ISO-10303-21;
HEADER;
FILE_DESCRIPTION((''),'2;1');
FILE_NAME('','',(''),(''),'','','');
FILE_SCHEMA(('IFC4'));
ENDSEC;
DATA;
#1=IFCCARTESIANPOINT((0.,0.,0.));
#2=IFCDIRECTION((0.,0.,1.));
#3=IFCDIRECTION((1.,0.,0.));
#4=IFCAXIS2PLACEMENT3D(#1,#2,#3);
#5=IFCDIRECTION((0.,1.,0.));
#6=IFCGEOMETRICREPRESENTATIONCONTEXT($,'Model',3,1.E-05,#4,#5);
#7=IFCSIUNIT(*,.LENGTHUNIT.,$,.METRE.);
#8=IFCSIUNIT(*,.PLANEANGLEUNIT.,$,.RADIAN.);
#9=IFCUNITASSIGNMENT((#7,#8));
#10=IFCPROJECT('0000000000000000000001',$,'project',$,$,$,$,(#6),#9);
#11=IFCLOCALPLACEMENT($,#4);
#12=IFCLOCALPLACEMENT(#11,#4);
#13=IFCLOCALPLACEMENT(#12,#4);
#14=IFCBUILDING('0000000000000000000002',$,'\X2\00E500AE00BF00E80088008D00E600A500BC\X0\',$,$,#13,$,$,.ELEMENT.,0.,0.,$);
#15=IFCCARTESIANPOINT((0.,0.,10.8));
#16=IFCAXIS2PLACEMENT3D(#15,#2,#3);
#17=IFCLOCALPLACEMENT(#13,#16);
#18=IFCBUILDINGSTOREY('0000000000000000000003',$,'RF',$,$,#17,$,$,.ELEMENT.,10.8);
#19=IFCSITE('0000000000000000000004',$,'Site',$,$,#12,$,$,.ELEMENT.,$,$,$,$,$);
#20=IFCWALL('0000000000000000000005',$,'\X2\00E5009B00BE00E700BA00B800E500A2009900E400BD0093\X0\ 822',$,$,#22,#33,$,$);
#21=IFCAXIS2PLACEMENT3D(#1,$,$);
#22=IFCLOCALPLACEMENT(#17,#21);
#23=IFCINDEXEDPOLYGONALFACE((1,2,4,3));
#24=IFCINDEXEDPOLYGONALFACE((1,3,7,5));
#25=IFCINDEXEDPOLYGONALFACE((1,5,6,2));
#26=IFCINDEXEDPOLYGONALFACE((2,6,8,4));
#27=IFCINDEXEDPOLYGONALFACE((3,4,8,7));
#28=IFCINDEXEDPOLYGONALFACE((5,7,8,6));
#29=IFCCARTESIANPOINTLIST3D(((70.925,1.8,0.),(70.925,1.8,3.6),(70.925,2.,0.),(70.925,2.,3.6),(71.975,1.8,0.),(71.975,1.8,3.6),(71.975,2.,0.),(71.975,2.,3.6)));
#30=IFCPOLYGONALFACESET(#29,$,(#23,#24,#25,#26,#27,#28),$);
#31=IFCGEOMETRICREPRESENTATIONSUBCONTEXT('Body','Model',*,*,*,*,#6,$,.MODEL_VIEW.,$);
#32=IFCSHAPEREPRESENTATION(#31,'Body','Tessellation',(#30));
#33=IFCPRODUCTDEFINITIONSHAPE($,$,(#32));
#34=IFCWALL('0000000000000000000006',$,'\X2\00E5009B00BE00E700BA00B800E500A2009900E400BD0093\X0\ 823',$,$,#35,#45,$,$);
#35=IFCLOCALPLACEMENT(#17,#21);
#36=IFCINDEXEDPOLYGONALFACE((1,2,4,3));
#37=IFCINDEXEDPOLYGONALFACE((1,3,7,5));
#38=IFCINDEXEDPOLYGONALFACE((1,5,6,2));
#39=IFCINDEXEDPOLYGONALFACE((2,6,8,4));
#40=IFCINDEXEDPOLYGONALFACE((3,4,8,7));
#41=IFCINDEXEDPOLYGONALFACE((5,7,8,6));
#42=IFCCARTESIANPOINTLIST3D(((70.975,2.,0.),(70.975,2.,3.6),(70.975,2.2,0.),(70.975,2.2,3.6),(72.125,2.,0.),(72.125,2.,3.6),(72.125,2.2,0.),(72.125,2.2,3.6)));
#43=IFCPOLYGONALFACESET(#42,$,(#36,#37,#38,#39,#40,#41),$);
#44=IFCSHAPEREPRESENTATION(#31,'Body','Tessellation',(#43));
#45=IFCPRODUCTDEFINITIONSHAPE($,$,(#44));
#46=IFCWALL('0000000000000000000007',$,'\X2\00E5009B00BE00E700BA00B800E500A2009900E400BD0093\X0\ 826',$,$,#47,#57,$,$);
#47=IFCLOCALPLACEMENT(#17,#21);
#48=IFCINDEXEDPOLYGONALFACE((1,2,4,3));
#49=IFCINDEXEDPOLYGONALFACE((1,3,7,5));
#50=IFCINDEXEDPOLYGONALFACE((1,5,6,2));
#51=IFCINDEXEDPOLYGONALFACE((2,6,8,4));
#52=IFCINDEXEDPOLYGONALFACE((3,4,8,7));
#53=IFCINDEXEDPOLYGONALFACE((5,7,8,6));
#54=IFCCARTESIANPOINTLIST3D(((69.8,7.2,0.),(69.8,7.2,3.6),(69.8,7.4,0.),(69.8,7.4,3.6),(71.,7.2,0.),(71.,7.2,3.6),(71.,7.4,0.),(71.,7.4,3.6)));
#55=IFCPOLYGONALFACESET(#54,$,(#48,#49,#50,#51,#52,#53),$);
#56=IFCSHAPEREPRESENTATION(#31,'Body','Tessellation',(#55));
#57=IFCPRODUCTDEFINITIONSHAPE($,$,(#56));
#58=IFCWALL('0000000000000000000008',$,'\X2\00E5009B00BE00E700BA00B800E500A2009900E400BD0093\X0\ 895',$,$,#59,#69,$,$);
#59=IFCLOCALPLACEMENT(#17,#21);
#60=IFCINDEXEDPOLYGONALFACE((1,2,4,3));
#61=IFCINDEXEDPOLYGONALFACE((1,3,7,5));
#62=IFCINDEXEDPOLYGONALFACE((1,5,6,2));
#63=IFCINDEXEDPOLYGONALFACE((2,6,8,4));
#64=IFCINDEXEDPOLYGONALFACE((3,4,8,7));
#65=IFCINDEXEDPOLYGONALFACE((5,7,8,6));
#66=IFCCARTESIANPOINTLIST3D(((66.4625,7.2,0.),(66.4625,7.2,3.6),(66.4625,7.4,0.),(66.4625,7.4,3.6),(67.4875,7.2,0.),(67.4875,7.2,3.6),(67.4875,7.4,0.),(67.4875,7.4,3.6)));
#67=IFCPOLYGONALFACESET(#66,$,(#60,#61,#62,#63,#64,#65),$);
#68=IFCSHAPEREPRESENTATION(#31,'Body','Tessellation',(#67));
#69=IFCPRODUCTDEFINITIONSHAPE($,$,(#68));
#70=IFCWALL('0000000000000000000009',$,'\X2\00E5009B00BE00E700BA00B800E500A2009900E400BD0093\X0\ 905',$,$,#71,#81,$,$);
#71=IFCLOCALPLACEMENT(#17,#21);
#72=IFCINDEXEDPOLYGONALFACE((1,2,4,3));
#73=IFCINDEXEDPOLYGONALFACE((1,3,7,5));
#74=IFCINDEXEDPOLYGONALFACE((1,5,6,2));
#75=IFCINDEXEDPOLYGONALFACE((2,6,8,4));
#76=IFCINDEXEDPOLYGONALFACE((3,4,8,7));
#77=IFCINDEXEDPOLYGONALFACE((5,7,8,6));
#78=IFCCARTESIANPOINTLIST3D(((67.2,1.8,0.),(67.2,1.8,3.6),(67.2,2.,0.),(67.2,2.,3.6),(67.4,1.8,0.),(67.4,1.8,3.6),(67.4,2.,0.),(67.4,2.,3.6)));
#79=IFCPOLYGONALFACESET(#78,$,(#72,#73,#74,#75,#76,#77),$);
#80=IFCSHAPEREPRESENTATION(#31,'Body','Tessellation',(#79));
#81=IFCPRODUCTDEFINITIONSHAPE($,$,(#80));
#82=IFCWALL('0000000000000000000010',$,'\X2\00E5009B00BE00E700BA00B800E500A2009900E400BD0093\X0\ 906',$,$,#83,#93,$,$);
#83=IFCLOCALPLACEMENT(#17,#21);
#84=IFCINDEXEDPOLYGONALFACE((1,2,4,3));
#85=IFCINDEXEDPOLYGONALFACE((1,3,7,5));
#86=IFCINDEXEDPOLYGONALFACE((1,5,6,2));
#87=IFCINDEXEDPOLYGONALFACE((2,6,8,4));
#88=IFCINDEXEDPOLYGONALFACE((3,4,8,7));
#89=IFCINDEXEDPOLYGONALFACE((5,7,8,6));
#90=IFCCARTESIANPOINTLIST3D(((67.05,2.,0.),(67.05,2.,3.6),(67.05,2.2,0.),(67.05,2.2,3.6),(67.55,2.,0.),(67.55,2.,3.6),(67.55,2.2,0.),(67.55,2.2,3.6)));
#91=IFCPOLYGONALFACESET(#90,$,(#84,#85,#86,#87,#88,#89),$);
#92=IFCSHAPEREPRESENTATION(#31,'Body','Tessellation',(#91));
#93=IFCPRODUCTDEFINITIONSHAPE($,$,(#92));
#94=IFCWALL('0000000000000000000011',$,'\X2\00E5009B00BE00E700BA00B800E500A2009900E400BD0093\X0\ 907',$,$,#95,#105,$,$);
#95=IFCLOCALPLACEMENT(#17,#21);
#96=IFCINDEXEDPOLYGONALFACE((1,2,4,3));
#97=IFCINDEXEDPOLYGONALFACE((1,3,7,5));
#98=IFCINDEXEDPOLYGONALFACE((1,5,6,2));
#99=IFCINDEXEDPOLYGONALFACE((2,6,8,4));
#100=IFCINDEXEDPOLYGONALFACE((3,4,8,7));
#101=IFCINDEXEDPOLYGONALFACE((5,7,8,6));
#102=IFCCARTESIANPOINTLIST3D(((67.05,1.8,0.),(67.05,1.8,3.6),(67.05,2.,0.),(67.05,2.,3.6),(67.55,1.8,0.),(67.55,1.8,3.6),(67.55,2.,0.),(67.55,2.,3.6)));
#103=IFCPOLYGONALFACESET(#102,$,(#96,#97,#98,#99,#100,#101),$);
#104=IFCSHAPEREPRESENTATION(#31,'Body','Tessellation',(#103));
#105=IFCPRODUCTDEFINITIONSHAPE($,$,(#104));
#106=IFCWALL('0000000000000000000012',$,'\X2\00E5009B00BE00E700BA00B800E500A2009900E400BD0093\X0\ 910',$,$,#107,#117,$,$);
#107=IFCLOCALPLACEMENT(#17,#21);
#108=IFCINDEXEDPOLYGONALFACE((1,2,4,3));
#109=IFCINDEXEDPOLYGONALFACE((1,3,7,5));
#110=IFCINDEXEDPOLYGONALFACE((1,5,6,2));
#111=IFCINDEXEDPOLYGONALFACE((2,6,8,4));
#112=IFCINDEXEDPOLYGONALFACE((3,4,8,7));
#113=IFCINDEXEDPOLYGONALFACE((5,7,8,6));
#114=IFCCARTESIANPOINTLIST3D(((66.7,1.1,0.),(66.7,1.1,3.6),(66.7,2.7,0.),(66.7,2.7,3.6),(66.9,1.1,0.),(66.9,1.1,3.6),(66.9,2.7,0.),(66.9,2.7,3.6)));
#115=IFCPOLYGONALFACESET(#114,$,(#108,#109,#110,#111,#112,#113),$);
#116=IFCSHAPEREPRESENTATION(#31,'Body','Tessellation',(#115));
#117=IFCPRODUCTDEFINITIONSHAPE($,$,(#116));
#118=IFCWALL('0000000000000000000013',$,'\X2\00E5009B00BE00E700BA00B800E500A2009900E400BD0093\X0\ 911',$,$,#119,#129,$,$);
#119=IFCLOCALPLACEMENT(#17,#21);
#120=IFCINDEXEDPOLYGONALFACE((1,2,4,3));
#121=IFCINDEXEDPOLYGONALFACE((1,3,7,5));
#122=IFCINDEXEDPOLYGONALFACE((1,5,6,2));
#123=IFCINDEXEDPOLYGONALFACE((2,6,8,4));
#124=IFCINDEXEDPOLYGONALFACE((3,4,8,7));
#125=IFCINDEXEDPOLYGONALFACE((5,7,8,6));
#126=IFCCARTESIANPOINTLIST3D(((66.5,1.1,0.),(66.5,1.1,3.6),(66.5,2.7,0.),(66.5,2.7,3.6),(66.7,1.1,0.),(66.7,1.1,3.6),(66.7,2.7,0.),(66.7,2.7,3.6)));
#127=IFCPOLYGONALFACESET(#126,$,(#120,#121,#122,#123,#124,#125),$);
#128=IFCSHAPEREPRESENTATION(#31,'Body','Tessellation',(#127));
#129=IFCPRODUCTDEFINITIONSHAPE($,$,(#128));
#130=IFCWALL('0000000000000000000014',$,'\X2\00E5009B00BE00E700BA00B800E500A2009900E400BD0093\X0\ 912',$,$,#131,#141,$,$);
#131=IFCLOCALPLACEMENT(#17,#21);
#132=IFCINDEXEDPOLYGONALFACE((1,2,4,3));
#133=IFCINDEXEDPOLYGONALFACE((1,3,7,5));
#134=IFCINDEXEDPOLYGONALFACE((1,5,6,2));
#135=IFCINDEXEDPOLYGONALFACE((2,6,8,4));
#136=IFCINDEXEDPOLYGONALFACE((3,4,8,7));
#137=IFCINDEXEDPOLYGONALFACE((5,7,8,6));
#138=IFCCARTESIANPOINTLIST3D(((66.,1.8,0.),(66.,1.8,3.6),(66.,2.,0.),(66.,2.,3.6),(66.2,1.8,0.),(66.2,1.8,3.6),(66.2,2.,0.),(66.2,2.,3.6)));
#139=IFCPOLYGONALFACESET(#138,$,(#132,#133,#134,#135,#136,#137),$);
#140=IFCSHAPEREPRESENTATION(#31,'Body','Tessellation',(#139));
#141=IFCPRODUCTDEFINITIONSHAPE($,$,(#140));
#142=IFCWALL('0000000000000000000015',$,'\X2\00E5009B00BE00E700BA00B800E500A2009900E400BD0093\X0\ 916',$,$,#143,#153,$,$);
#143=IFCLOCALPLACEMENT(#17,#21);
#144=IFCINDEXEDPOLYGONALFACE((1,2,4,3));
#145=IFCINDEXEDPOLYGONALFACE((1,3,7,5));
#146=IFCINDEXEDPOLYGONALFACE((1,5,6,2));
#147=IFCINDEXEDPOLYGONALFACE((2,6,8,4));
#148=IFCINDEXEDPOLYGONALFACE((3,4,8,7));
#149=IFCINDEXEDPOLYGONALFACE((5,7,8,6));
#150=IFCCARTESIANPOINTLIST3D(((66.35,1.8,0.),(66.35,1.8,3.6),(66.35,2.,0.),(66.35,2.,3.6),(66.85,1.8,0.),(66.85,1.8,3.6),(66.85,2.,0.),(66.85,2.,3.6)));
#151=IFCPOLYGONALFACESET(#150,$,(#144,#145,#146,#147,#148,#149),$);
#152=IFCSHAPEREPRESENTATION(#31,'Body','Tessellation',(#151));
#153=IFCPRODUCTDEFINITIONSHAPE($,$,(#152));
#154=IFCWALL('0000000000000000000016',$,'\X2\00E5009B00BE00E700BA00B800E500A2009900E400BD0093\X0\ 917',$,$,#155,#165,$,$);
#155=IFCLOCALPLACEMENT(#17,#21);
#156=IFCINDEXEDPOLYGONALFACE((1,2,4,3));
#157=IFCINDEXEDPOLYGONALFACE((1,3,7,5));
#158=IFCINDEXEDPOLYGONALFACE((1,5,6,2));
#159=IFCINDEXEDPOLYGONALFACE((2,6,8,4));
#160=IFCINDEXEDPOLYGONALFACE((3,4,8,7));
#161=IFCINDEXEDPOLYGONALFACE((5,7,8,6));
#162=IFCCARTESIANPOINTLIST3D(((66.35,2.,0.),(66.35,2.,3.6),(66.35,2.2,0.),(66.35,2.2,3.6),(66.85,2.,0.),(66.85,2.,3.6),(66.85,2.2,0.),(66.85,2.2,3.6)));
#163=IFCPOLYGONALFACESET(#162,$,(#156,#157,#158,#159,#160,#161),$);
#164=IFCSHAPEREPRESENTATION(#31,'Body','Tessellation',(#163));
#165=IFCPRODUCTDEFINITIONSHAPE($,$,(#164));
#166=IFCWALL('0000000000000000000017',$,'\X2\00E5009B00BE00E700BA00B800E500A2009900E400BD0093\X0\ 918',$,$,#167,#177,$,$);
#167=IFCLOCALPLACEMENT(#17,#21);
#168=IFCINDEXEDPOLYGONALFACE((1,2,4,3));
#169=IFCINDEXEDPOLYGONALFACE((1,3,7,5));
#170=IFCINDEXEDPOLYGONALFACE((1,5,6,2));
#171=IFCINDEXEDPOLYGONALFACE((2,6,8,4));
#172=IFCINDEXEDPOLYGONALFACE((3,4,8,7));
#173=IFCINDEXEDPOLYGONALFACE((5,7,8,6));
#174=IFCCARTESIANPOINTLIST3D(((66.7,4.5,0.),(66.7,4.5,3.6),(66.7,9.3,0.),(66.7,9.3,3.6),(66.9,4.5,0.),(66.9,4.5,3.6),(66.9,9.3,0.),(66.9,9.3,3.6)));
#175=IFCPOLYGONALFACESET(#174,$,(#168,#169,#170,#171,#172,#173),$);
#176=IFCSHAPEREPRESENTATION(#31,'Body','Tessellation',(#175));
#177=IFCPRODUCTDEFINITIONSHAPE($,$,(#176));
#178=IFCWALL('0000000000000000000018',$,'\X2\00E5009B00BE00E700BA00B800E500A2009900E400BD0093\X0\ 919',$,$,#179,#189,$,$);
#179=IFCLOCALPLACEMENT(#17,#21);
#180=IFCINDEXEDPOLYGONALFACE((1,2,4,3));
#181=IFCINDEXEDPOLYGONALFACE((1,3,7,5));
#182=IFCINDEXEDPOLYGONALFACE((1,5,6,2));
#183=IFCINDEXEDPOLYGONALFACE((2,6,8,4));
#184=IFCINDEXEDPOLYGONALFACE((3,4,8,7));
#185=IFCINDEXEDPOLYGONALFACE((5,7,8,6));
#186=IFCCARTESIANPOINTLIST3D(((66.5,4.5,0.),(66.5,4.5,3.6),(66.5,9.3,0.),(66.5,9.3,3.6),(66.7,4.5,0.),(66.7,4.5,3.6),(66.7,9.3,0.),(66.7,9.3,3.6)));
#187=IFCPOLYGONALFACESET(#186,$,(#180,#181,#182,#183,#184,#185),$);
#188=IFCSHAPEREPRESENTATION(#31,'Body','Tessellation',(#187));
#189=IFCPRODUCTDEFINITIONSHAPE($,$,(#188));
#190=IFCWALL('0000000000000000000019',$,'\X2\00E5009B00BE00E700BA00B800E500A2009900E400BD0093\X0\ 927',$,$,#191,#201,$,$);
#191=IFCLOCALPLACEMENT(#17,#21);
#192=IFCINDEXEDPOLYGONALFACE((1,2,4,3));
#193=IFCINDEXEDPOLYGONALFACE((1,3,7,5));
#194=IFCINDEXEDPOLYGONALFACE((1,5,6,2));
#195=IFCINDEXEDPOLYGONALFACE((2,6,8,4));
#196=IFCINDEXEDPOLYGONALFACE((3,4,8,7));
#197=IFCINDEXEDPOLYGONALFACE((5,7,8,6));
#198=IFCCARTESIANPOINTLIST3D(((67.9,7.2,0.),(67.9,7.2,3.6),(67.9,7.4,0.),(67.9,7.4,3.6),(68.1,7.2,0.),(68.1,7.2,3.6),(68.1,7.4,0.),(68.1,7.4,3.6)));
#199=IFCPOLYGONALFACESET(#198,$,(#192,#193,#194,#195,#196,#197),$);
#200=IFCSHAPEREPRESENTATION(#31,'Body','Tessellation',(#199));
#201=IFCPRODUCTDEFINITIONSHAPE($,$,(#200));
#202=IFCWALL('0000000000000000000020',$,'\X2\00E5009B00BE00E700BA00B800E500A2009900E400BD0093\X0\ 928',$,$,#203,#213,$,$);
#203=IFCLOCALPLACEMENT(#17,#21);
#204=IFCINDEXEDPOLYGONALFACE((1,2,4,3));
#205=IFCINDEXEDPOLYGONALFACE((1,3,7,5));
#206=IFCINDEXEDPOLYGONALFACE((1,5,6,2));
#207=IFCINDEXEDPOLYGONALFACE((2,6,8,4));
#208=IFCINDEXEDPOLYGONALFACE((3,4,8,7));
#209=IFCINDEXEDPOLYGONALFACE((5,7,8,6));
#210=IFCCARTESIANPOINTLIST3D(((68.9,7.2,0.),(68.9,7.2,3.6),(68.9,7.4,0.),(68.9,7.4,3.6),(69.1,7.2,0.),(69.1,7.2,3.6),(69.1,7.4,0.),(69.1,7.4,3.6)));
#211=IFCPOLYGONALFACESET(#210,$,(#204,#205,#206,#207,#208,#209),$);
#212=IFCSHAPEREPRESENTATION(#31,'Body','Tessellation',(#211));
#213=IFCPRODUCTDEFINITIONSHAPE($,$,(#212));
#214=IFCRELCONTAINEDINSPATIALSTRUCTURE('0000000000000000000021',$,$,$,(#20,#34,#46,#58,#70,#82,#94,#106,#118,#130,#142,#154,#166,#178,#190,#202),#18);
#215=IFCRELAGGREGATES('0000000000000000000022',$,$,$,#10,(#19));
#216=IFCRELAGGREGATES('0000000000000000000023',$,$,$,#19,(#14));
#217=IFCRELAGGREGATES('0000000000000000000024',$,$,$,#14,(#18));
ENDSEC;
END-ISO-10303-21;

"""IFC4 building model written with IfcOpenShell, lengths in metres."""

from ifc_helpers import new_model, si_unit, direction, frame, frame_2d, origin_with_axes, place, context, subcontext, project, spatial, rectangle, extrude, element, save


model = new_model("IFC4")

# Units and contexts
model_context = context("Model", 3, precision=1e-05, world=origin_with_axes(), true_north=direction((0.0, 1.0, 0.0)))
body_context = subcontext(model_context, "Body", "Model", "MODEL_VIEW")
ifc_project = project(units=[si_unit("LENGTHUNIT", "METRE"), si_unit("PLANEANGLEUNIT", "RADIAN")], contexts=[model_context])

# Site, building, storey
placement = place(None, origin_with_axes())
site_placement = place(placement, origin_with_axes())
site = spatial("IfcSite", under=ifc_project, at=site_placement, Name="Site", CompositionType="ELEMENT")
building_placement = place(site_placement, origin_with_axes())
building = spatial("IfcBuilding", under=site, at=building_placement, Name="å®¿è\u0088\u008dæ¥¼", CompositionType="ELEMENT", ElevationOfRefHeight=0.0, ElevationOfTerrain=0.0)
storey_placement = place(building_placement, frame((0.0, 0.0, 10.8), z_axis=(0.0, 0.0, 1.0), x_axis=(1.0, 0.0, 0.0)))
storey = spatial("IfcBuildingStorey", under=building, at=storey_placement, Name="RF", CompositionType="ELEMENT", Elevation=10.8)

# Walls
wall_1_placement = place(storey_placement, frame((71.45, 1.9, 0.0), z_axis=(0.0, 0.0, 1.0), x_axis=(-1.0, 0.0, 0.0)))
element("IfcWall", 1, at=wall_1_placement, inside=storey, Name="å\u009b¾çº¸å¢\u0099ä½\u0093 822", context=body_context, shape_type="SweptSolid", body=[
    extrude(rectangle(XDim=1.05, YDim=0.2, at=frame_2d((0.0, 0.0), x_axis=(1.0, 0.0, 0.0))), frame((0.0, 0.0, 0.0), z_axis=(0.0, 0.0, 1.0)), (0.0, 0.0, 1.0), 3.6),
])
wall_2_placement = place(storey_placement, frame((71.55, 2.1, 0.0), z_axis=(0.0, 0.0, 1.0), x_axis=(-1.0, 0.0, 0.0)))
element("IfcWall", 2, at=wall_2_placement, inside=storey, Name="å\u009b¾çº¸å¢\u0099ä½\u0093 823", context=body_context, shape_type="SweptSolid", body=[
    extrude(rectangle(XDim=1.15, YDim=0.2, at=frame_2d((0.0, 0.0), x_axis=(1.0, 0.0, 0.0))), frame((0.0, 0.0, 0.0), z_axis=(0.0, 0.0, 1.0)), (0.0, 0.0, 1.0), 3.6),
])
wall_3_placement = place(storey_placement, frame((70.4, 7.3, 0.0), z_axis=(0.0, 0.0, 1.0), x_axis=(1.0, 0.0, 0.0)))
element("IfcWall", 3, at=wall_3_placement, inside=storey, Name="å\u009b¾çº¸å¢\u0099ä½\u0093 826", context=body_context, shape_type="SweptSolid", body=[
    extrude(rectangle(XDim=1.2, YDim=0.2, at=frame_2d((0.0, 0.0), x_axis=(1.0, 0.0, 0.0))), frame((0.0, 0.0, 0.0), z_axis=(0.0, 0.0, 1.0)), (0.0, 0.0, 1.0), 3.6),
])
wall_4_placement = place(storey_placement, frame((66.975, 7.3, 0.0), z_axis=(0.0, 0.0, 1.0), x_axis=(1.0, 0.0, 0.0)))
element("IfcWall", 4, at=wall_4_placement, inside=storey, Name="å\u009b¾çº¸å¢\u0099ä½\u0093 895", context=body_context, shape_type="SweptSolid", body=[
    extrude(rectangle(XDim=1.025, YDim=0.2, at=frame_2d((0.0, 0.0), x_axis=(1.0, 0.0, 0.0))), frame((0.0, 0.0, 0.0), z_axis=(0.0, 0.0, 1.0)), (0.0, 0.0, 1.0), 3.6),
])
wall_5_placement = place(storey_placement, frame((67.3, 1.9, 0.0), z_axis=(0.0, 0.0, 1.0), x_axis=(0.0, 1.0, 0.0)))
element("IfcWall", 5, at=wall_5_placement, inside=storey, Name="å\u009b¾çº¸å¢\u0099ä½\u0093 905", context=body_context, shape_type="SweptSolid", body=[
    extrude(rectangle(XDim=0.2, YDim=0.2, at=frame_2d((0.0, 0.0), x_axis=(1.0, 0.0, 0.0))), frame((0.0, 0.0, 0.0), z_axis=(0.0, 0.0, 1.0)), (0.0, 0.0, 1.0), 3.6),
])
for number, where, z_axis, x_axis, name in (
    (6, (67.3, 2.1, 0.0), (0.0, 0.0, 1.0), (-1.0, 0.0, 0.0), "å\u009b¾çº¸å¢\u0099ä½\u0093 906"),
    (7, (67.3, 1.9, 0.0), (0.0, 0.0, 1.0), (-1.0, 0.0, 0.0), "å\u009b¾çº¸å¢\u0099ä½\u0093 907"),
):
    element("IfcWall", number, at=place(storey_placement, frame(where, z_axis=z_axis, x_axis=x_axis)), inside=storey, Name=name, context=body_context, shape_type="SweptSolid", body=[
        extrude(rectangle(XDim=0.5, YDim=0.2, at=frame_2d((0.0, 0.0), x_axis=(1.0, 0.0, 0.0))), frame((0.0, 0.0, 0.0), z_axis=(0.0, 0.0, 1.0)), (0.0, 0.0, 1.0), 3.6),
    ])
for number, where, z_axis, x_axis, name in (
    (8, (66.8, 1.9, 0.0), (0.0, 0.0, 1.0), (0.0, -1.0, 0.0), "å\u009b¾çº¸å¢\u0099ä½\u0093 910"),
    (9, (66.6, 1.9, 0.0), (0.0, 0.0, 1.0), (0.0, -1.0, 0.0), "å\u009b¾çº¸å¢\u0099ä½\u0093 911"),
):
    element("IfcWall", number, at=place(storey_placement, frame(where, z_axis=z_axis, x_axis=x_axis)), inside=storey, Name=name, context=body_context, shape_type="SweptSolid", body=[
        extrude(rectangle(XDim=1.6, YDim=0.2, at=frame_2d((0.0, 0.0), x_axis=(1.0, 0.0, 0.0))), frame((0.0, 0.0, 0.0), z_axis=(0.0, 0.0, 1.0)), (0.0, 0.0, 1.0), 3.6),
    ])
wall_6_placement = place(storey_placement, frame((66.1, 1.9, 0.0), z_axis=(0.0, 0.0, 1.0), x_axis=(0.0, 1.0, 0.0)))
element("IfcWall", 10, at=wall_6_placement, inside=storey, Name="å\u009b¾çº¸å¢\u0099ä½\u0093 912", context=body_context, shape_type="SweptSolid", body=[
    extrude(rectangle(XDim=0.2, YDim=0.2, at=frame_2d((0.0, 0.0), x_axis=(1.0, 0.0, 0.0))), frame((0.0, 0.0, 0.0), z_axis=(0.0, 0.0, 1.0)), (0.0, 0.0, 1.0), 3.6),
])
for number, where, z_axis, x_axis, name in (
    (11, (66.6, 1.9, 0.0), (0.0, 0.0, 1.0), (-1.0, 0.0, 0.0), "å\u009b¾çº¸å¢\u0099ä½\u0093 916"),
    (12, (66.6, 2.1, 0.0), (0.0, 0.0, 1.0), (-1.0, 0.0, 0.0), "å\u009b¾çº¸å¢\u0099ä½\u0093 917"),
):
    element("IfcWall", number, at=place(storey_placement, frame(where, z_axis=z_axis, x_axis=x_axis)), inside=storey, Name=name, context=body_context, shape_type="SweptSolid", body=[
        extrude(rectangle(XDim=0.5, YDim=0.2, at=frame_2d((0.0, 0.0), x_axis=(1.0, 0.0, 0.0))), frame((0.0, 0.0, 0.0), z_axis=(0.0, 0.0, 1.0)), (0.0, 0.0, 1.0), 3.6),
    ])
for number, where, z_axis, x_axis, name in (
    (13, (66.8, 6.9, 0.0), (0.0, 0.0, 1.0), (0.0, -1.0, 0.0), "å\u009b¾çº¸å¢\u0099ä½\u0093 918"),
    (14, (66.6, 6.9, 0.0), (0.0, 0.0, 1.0), (0.0, -1.0, 0.0), "å\u009b¾çº¸å¢\u0099ä½\u0093 919"),
):
    element("IfcWall", number, at=place(storey_placement, frame(where, z_axis=z_axis, x_axis=x_axis)), inside=storey, Name=name, context=body_context, shape_type="SweptSolid", body=[
        extrude(rectangle(XDim=4.8, YDim=0.2, at=frame_2d((0.0, 0.0), x_axis=(1.0, 0.0, 0.0))), frame((0.0, 0.0, 0.0), z_axis=(0.0, 0.0, 1.0)), (0.0, 0.0, 1.0), 3.6),
    ])
for number, where, z_axis, x_axis, name in (
    (15, (68.0, 7.3, 0.0), (0.0, 0.0, 1.0), (0.0, 1.0, 0.0), "å\u009b¾çº¸å¢\u0099ä½\u0093 927"),
    (16, (69.0, 7.3, 0.0), (0.0, 0.0, 1.0), (0.0, 1.0, 0.0), "å\u009b¾çº¸å¢\u0099ä½\u0093 928"),
):
    element("IfcWall", number, at=place(storey_placement, frame(where, z_axis=z_axis, x_axis=x_axis)), inside=storey, Name=name, context=body_context, shape_type="SweptSolid", body=[
        extrude(rectangle(XDim=0.2, YDim=0.2, at=frame_2d((0.0, 0.0), x_axis=(1.0, 0.0, 0.0))), frame((0.0, 0.0, 0.0), z_axis=(0.0, 0.0, 1.0)), (0.0, 0.0, 1.0), 3.6),
    ])

save(model, "model.ifc")
